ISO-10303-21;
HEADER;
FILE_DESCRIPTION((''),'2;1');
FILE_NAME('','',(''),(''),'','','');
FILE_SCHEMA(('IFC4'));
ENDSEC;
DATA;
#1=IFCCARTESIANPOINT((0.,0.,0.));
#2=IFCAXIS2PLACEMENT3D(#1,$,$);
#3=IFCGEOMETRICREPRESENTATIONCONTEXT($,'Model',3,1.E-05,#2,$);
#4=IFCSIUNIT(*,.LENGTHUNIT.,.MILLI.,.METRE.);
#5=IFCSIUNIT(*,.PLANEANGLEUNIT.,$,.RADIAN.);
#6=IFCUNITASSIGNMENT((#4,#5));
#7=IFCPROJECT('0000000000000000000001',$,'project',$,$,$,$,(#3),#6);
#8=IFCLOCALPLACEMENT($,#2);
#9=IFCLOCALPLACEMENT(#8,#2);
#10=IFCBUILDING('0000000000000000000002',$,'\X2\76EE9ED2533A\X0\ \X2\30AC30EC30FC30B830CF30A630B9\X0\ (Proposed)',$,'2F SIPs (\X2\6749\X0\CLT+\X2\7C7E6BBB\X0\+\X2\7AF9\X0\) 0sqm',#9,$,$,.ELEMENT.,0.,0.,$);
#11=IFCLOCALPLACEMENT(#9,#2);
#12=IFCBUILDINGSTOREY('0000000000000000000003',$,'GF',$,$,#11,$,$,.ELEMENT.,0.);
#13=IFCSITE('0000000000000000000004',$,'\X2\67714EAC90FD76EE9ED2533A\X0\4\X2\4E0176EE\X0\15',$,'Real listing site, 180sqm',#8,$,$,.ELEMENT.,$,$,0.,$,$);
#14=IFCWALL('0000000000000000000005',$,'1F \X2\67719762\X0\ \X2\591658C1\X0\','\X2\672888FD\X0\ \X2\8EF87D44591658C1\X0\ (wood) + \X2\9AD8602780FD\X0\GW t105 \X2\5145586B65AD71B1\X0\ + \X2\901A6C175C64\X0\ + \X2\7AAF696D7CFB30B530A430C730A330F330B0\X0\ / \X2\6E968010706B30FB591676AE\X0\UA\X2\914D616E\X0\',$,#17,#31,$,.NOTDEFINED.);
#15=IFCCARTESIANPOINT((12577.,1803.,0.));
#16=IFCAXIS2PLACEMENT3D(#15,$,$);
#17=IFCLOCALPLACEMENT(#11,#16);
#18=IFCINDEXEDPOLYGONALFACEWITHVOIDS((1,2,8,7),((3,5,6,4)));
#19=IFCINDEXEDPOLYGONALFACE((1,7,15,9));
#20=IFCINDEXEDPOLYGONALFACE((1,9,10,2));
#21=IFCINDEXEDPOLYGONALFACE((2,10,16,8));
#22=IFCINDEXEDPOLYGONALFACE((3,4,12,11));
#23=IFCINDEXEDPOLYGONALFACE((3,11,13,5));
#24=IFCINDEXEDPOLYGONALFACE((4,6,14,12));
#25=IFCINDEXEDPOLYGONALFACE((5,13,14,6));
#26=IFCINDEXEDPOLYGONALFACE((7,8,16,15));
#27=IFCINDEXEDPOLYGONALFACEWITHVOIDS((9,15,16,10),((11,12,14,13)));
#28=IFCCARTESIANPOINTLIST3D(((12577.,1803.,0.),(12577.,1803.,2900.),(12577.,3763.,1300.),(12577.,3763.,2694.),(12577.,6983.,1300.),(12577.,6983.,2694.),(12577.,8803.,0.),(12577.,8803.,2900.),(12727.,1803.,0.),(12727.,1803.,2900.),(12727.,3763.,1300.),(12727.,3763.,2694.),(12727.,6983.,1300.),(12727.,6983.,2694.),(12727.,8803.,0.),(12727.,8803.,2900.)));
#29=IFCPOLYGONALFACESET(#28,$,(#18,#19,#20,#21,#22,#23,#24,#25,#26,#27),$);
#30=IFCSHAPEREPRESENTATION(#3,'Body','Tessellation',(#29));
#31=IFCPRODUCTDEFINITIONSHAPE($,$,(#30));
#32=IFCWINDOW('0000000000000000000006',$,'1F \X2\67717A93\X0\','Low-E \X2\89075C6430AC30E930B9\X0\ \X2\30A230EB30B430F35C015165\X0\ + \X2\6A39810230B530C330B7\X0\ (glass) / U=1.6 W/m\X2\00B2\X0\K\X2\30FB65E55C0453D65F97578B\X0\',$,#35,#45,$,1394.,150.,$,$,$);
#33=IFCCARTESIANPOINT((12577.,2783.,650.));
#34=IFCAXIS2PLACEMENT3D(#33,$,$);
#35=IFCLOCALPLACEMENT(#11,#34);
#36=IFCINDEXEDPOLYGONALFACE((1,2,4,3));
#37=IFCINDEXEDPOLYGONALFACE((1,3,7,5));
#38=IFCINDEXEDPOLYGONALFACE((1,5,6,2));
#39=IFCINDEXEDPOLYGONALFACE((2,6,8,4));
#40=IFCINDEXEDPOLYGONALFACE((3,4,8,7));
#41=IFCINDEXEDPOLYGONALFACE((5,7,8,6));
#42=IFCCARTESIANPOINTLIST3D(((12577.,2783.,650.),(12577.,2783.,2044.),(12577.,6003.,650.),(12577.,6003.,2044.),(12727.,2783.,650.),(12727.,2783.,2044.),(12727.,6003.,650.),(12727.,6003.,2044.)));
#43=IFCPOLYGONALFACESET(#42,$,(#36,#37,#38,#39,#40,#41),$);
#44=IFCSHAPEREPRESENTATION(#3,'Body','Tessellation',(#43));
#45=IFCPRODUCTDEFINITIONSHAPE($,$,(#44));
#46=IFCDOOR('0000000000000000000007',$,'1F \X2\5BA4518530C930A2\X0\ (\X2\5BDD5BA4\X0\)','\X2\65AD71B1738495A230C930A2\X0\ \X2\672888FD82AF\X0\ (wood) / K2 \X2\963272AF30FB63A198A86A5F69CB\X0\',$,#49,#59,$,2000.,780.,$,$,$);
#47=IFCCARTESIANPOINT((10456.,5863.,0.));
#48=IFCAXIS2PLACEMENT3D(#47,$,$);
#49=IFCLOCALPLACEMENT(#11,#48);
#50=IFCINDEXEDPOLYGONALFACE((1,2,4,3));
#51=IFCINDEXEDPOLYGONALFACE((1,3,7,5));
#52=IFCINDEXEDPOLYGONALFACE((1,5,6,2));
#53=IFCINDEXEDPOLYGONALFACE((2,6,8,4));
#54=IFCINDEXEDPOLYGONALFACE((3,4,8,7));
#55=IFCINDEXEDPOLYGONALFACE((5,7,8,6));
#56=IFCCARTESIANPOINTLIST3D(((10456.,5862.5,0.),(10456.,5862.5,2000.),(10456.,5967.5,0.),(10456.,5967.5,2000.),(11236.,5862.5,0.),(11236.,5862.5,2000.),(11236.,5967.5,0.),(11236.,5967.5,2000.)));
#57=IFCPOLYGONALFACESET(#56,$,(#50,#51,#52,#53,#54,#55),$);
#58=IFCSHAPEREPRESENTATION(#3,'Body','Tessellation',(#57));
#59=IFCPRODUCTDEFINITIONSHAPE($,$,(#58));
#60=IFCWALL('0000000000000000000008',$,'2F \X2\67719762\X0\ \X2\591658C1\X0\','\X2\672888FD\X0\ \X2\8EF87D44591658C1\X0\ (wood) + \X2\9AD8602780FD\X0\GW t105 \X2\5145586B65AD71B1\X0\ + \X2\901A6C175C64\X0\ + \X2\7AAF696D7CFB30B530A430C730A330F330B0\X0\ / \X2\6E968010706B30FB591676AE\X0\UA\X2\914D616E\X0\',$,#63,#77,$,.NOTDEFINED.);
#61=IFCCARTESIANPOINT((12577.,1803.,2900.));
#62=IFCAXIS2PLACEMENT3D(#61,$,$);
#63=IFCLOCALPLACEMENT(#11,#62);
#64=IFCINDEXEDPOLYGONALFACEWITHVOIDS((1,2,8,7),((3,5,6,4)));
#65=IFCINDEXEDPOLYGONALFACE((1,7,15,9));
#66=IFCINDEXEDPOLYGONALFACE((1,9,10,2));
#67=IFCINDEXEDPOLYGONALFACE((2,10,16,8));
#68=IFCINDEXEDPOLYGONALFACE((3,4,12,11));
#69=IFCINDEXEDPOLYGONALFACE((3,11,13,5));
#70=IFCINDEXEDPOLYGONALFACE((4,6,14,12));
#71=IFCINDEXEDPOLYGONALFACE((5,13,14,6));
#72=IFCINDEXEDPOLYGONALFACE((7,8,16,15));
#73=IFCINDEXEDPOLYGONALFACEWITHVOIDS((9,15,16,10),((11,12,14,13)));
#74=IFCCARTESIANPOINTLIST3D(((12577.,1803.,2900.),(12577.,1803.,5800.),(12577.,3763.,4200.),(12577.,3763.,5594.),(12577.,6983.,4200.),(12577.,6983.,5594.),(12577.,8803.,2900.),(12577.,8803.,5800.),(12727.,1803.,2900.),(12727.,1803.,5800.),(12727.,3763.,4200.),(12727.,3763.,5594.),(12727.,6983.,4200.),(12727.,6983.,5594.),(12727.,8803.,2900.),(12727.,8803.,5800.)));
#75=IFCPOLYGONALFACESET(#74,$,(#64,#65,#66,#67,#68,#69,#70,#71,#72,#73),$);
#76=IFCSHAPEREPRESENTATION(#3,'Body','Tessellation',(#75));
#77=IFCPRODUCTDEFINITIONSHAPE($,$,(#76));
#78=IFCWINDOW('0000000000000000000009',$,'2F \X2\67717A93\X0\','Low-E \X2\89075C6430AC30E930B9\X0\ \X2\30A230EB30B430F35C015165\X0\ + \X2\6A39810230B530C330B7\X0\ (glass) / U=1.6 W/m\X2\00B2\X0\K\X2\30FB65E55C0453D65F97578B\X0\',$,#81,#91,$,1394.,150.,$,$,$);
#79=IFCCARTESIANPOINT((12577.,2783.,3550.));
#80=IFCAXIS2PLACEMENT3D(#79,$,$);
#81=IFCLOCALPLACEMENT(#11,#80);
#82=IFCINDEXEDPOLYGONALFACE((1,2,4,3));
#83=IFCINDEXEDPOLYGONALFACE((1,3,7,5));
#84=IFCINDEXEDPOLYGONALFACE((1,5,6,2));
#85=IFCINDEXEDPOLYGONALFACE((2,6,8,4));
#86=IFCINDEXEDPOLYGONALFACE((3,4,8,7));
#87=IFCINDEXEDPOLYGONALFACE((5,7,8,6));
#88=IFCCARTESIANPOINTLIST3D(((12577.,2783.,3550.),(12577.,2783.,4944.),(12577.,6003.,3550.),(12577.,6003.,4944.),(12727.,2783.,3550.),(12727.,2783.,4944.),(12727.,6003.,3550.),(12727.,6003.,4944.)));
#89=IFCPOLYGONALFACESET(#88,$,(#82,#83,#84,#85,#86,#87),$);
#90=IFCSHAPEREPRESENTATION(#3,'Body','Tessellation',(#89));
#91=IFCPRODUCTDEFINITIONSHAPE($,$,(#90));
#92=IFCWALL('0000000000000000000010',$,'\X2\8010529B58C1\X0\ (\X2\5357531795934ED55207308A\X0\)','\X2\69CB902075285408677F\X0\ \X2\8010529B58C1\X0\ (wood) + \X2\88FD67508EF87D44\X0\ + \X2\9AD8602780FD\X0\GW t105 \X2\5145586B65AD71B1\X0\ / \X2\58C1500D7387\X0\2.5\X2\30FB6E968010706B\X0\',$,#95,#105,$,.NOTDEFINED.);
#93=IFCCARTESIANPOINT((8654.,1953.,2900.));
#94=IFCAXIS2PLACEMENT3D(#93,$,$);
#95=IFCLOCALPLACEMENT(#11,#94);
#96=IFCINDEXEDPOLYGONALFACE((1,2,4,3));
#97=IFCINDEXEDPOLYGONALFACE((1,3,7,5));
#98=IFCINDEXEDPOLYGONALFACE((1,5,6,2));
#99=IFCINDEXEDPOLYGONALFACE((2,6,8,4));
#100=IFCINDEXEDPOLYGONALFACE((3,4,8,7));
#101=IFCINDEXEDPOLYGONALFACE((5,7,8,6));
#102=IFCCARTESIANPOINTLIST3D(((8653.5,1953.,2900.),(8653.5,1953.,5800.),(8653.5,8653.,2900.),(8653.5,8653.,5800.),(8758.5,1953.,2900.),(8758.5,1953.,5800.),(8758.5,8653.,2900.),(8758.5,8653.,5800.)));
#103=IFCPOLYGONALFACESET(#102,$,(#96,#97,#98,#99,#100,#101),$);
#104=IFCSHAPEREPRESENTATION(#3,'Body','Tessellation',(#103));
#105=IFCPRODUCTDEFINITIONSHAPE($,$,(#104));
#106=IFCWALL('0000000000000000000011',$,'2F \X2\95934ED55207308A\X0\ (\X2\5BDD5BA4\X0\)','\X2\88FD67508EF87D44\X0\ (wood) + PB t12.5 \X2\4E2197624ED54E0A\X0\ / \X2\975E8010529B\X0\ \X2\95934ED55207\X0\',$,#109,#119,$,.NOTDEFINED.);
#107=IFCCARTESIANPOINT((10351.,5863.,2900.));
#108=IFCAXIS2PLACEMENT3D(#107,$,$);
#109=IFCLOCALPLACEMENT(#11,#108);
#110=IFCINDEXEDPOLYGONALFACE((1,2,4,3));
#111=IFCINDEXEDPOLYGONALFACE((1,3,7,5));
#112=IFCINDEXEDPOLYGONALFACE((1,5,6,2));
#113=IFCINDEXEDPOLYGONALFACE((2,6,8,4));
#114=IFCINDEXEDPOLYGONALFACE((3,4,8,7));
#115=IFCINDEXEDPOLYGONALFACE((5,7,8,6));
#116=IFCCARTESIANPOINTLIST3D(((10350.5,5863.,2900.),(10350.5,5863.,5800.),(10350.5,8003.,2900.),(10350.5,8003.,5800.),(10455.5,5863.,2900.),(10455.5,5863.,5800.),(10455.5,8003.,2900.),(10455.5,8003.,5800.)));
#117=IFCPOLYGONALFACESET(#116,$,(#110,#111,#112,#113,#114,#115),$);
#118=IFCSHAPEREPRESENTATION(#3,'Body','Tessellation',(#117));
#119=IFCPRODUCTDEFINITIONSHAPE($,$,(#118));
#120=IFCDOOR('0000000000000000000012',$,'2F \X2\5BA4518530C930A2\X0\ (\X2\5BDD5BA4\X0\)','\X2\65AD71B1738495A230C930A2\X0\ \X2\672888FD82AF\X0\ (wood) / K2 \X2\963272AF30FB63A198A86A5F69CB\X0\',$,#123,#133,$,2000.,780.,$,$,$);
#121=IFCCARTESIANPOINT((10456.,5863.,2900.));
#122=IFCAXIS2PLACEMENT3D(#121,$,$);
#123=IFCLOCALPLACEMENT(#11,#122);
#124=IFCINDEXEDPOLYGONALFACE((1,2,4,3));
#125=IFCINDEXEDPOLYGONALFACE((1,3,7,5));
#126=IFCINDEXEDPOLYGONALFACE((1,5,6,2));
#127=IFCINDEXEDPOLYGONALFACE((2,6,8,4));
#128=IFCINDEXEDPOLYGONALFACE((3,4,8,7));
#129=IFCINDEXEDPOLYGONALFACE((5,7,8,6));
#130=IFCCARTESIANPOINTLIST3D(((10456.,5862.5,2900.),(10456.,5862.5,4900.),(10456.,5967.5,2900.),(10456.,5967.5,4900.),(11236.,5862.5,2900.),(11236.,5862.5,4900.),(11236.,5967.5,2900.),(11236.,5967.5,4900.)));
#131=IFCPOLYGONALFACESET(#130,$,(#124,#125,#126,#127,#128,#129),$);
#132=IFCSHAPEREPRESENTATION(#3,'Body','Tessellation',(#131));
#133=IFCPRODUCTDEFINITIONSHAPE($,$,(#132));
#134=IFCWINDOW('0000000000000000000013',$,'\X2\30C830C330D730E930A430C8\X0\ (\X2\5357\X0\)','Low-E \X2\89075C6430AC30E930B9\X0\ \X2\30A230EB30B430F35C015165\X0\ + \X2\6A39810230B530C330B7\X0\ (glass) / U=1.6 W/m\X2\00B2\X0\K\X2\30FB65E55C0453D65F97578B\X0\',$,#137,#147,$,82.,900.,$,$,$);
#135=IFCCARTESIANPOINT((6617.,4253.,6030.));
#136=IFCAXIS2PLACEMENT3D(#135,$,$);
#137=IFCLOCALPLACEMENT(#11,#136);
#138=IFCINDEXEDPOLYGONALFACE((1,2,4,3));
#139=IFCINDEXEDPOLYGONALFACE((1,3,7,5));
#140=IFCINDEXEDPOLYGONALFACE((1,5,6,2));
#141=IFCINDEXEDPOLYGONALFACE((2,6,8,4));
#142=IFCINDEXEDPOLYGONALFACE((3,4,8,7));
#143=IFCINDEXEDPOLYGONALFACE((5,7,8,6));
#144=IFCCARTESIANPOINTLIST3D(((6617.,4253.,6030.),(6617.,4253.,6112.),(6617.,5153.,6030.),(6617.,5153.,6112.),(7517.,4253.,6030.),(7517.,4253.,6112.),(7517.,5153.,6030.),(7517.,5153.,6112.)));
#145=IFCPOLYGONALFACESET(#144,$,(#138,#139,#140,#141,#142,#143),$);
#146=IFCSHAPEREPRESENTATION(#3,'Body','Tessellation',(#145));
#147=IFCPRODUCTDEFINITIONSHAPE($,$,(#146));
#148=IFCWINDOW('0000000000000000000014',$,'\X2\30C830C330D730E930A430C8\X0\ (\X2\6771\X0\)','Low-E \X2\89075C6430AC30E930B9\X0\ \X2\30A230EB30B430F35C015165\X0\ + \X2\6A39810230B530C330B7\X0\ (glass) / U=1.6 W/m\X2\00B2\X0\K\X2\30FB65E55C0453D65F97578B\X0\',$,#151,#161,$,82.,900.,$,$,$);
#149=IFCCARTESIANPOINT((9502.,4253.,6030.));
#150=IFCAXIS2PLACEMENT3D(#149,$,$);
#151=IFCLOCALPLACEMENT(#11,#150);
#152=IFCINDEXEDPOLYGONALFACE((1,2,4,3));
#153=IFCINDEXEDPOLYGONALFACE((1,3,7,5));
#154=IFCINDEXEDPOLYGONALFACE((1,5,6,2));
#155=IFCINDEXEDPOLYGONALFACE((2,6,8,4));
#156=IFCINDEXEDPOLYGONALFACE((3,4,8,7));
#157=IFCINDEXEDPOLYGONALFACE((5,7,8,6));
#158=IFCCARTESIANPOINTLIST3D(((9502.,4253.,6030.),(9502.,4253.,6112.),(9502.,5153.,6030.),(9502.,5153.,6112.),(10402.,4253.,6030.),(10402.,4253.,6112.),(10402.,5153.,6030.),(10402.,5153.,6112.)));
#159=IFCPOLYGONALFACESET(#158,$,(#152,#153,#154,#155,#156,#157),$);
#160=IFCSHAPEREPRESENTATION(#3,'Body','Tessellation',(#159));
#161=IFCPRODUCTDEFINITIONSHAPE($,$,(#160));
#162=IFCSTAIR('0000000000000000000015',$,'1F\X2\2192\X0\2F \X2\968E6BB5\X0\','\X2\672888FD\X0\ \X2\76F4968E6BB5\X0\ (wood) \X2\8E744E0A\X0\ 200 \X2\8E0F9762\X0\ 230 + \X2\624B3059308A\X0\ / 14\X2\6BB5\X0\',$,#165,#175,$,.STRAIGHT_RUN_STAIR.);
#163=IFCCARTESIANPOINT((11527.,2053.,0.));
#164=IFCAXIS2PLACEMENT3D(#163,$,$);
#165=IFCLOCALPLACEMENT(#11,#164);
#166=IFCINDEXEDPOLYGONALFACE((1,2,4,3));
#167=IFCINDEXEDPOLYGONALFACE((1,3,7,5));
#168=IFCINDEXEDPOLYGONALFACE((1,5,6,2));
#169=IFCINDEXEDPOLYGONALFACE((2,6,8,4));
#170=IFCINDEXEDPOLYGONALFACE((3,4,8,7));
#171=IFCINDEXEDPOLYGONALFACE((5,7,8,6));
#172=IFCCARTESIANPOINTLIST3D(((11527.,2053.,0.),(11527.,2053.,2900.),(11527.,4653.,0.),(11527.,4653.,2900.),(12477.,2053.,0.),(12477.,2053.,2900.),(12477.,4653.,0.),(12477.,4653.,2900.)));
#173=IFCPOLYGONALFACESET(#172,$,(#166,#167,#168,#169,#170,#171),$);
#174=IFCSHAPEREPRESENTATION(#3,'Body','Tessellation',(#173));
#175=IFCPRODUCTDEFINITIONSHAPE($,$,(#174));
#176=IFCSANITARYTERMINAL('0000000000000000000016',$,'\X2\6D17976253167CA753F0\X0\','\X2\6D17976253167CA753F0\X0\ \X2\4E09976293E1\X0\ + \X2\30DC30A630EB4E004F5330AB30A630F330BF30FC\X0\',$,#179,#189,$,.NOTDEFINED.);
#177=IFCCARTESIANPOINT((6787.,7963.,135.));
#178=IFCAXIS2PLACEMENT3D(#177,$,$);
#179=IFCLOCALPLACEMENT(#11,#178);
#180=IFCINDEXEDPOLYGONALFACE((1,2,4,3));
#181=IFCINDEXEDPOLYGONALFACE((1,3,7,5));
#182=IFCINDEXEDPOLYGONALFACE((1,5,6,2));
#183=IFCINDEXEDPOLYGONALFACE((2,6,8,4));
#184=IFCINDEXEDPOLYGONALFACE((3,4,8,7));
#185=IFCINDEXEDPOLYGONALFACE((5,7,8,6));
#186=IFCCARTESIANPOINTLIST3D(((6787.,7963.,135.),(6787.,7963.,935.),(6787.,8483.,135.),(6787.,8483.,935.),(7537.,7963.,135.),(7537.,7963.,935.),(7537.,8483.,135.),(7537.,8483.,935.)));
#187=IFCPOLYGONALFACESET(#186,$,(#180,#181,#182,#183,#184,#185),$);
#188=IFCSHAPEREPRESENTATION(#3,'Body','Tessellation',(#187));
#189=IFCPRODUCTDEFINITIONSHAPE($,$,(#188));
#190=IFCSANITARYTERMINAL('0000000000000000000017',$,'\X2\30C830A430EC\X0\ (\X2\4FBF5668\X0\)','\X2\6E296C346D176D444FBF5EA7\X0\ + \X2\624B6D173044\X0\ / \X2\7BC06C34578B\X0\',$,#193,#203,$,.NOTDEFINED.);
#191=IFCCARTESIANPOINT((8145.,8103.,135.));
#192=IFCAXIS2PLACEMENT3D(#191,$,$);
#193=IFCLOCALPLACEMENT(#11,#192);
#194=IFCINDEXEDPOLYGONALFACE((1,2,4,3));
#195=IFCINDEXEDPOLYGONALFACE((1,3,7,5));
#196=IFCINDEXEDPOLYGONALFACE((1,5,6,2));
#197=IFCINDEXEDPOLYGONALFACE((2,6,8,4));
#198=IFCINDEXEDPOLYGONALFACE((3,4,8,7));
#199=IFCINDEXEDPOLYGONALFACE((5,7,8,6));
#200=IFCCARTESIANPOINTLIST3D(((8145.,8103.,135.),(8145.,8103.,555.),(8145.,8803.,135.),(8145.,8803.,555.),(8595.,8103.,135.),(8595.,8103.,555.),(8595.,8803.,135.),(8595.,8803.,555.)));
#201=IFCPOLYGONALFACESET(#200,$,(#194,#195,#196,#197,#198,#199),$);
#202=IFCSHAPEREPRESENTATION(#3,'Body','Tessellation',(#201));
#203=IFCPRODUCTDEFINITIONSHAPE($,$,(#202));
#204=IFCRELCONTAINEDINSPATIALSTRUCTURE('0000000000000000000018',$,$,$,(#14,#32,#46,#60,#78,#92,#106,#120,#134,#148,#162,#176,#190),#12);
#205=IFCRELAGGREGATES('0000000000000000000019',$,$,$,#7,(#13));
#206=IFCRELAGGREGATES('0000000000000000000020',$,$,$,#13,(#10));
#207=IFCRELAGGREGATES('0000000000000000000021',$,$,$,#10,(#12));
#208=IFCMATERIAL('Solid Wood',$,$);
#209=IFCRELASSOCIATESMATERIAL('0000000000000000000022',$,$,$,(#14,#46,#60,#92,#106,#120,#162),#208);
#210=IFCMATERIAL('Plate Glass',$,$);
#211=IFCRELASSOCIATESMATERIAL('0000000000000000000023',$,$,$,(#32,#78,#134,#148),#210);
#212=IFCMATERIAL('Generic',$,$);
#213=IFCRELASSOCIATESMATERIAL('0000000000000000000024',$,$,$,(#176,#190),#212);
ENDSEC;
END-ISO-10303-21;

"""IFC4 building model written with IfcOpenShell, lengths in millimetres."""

from ifc_helpers import new_model, si_unit, frame, frame_2d, origin, place, context, project, spatial, rectangle, extrude, material, element, fill, save


model = new_model("IFC4")

# Units and contexts
model_context = context("Model", 3, precision=1e-05, world=origin())
ifc_project = project(units=[si_unit("LENGTHUNIT", "METRE", prefix="MILLI"), si_unit("PLANEANGLEUNIT", "RADIAN")], contexts=[model_context])

# Site, building, storey
site_placement = place(None, origin())
site = spatial("IfcSite", under=ifc_project, at=site_placement, Name="東京都目黒区4丁目15", ObjectType="Real listing site, 180sqm", CompositionType="ELEMENT", RefElevation=0.0)
building_placement = place(site_placement, origin())
building = spatial("IfcBuilding", under=site, at=building_placement, Name="目黒区 ガレージハウス (Proposed)", ObjectType="2F SIPs (杉CLT+籾殻+竹) 0sqm", CompositionType="ELEMENT", ElevationOfRefHeight=0.0, ElevationOfTerrain=0.0)
storey_placement = place(building_placement, origin())
storey = spatial("IfcBuildingStorey", under=building, at=storey_placement, Name="GF", CompositionType="ELEMENT", Elevation=0.0)

# Wall, opening, window
ifc_material_1 = material(Name="Solid Wood")
wall_1_placement = place(storey_placement, frame((12577.0, 1803.0, 0.0)))
wall_1 = element("IfcWall", 1, at=wall_1_placement, inside=storey, material=ifc_material_1, Name="1F 東面 外壁", Description="木製 軸組外壁 (wood) + 高性能GW t105 充填断熱 + 通気層 + 窯業系サイディング / 準耐火・外皮UA配慮", PredefinedType="NOTDEFINED", context=model_context, shape_type="SweptSolid", body=[
    extrude(rectangle(XDim=150.0, YDim=7000.0, at=frame_2d((75.0, 3500.0))), frame((12577.0, 1803.0, 0.0)), (0.0, 0.0, 1.0), 2900.0),
])
opening_1_placement = place(storey_placement, frame((12577.0, 2783.0, 650.0)))
opening_1 = element("IfcOpeningElement", 2, at=opening_1_placement, cuts=wall_1, PredefinedType="NOTDEFINED", context=model_context, shape_type="SweptSolid", body=[
    extrude(rectangle(XDim=150.0, YDim=3220.0, at=frame_2d((75.0, 1610.0))), frame((12577.0, 2783.0, 650.0)), (0.0, 0.0, 1.0), 1394.0),
])
ifc_material_2 = material(Name="Plate Glass")
window_1_placement = place(storey_placement, frame((12577.0, 2783.0, 650.0)))
window_1 = element("IfcWindow", 3, at=window_1_placement, inside=storey, material=ifc_material_2, Name="1F 東窓", Description="Low-E 複層ガラス アルゴン封入 + 樹脂サッシ (glass) / U=1.6 W/m²K・日射取得型", OverallHeight=1394.0, OverallWidth=150.0, context=model_context, shape_type="SweptSolid", body=[
    extrude(rectangle(XDim=150.0, YDim=3220.0, at=frame_2d((75.0, 1610.0))), frame((12577.0, 2783.0, 650.0)), (0.0, 0.0, 1.0), 1394.0),
])
fill(opening_1, window_1)

# Door
door_1_placement = place(storey_placement, frame((10456.0, 5863.0, 0.0)))
element("IfcDoor", 4, at=door_1_placement, inside=storey, material=ifc_material_1, Name="1F 室内ドア (寝室)", Description="断熱玄関ドア 木製芯 (wood) / K2 防犯・採風機構", OverallHeight=2000.0, OverallWidth=780.0, context=model_context, shape_type="SweptSolid", body=[
    extrude(rectangle(XDim=780.0, YDim=105.0, at=frame_2d((390.0, 52.0))), frame((10456.0, 5863.0, 0.0)), (0.0, 0.0, 1.0), 2000.0),
])

# Wall, opening, window
wall_2_placement = place(storey_placement, frame((12577.0, 1803.0, 2900.0)))
wall_2 = element("IfcWall", 5, at=wall_2_placement, inside=storey, material=ifc_material_1, Name="2F 東面 外壁", Description="木製 軸組外壁 (wood) + 高性能GW t105 充填断熱 + 通気層 + 窯業系サイディング / 準耐火・外皮UA配慮", PredefinedType="NOTDEFINED", context=model_context, shape_type="SweptSolid", body=[
    extrude(rectangle(XDim=150.0, YDim=7000.0, at=frame_2d((75.0, 3500.0))), frame((12577.0, 1803.0, 2900.0)), (0.0, 0.0, 1.0), 2900.0),
])
opening_2_placement = place(storey_placement, frame((12577.0, 2783.0, 3550.0)))
opening_2 = element("IfcOpeningElement", 6, at=opening_2_placement, cuts=wall_2, PredefinedType="NOTDEFINED", context=model_context, shape_type="SweptSolid", body=[
    extrude(rectangle(XDim=150.0, YDim=3220.0, at=frame_2d((75.0, 1610.0))), frame((12577.0, 2783.0, 3550.0)), (0.0, 0.0, 1.0), 1394.0),
])
window_2_placement = place(storey_placement, frame((12577.0, 2783.0, 3550.0)))
window_2 = element("IfcWindow", 7, at=window_2_placement, inside=storey, material=ifc_material_2, Name="2F 東窓", Description="Low-E 複層ガラス アルゴン封入 + 樹脂サッシ (glass) / U=1.6 W/m²K・日射取得型", OverallHeight=1394.0, OverallWidth=150.0, context=model_context, shape_type="SweptSolid", body=[
    extrude(rectangle(XDim=150.0, YDim=3220.0, at=frame_2d((75.0, 1610.0))), frame((12577.0, 2783.0, 3550.0)), (0.0, 0.0, 1.0), 1394.0),
])
fill(opening_2, window_2)

# Walls
wall_3_placement = place(storey_placement, frame((8654.0, 1953.0, 2900.0)))
element("IfcWall", 8, at=wall_3_placement, inside=storey, material=ifc_material_1, Name="耐力壁 (南北間仕切り)", Description="構造用合板 耐力壁 (wood) + 製材軸組 + 高性能GW t105 充填断熱 / 壁倍率2.5・準耐火", PredefinedType="NOTDEFINED", context=model_context, shape_type="SweptSolid", body=[
    extrude(rectangle(XDim=105.0, YDim=6700.0, at=frame_2d((52.0, 3350.0))), frame((8654.0, 1953.0, 2900.0)), (0.0, 0.0, 1.0), 2900.0),
])
wall_4_placement = place(storey_placement, frame((10351.0, 5863.0, 2900.0)))
element("IfcWall", 9, at=wall_4_placement, inside=storey, material=ifc_material_1, Name="2F 間仕切り (寝室)", Description="製材軸組 (wood) + PB t12.5 両面仕上 / 非耐力 間仕切", PredefinedType="NOTDEFINED", context=model_context, shape_type="SweptSolid", body=[
    extrude(rectangle(XDim=105.0, YDim=2140.0, at=frame_2d((52.0, 1070.0))), frame((10351.0, 5863.0, 2900.0)), (0.0, 0.0, 1.0), 2900.0),
])

# Door
door_2_placement = place(storey_placement, frame((10456.0, 5863.0, 2900.0)))
element("IfcDoor", 10, at=door_2_placement, inside=storey, material=ifc_material_1, Name="2F 室内ドア (寝室)", Description="断熱玄関ドア 木製芯 (wood) / K2 防犯・採風機構", OverallHeight=2000.0, OverallWidth=780.0, context=model_context, shape_type="SweptSolid", body=[
    extrude(rectangle(XDim=780.0, YDim=105.0, at=frame_2d((390.0, 52.0))), frame((10456.0, 5863.0, 2900.0)), (0.0, 0.0, 1.0), 2000.0),
])

# Windows
window_3_placement = place(storey_placement, frame((6617.0, 4253.0, 6030.0)))
element("IfcWindow", 11, at=window_3_placement, inside=storey, material=ifc_material_2, Name="トップライト (南)", Description="Low-E 複層ガラス アルゴン封入 + 樹脂サッシ (glass) / U=1.6 W/m²K・日射取得型", OverallHeight=82.0, OverallWidth=900.0, context=model_context, shape_type="SweptSolid", body=[
    extrude(rectangle(XDim=900.0, YDim=900.0, at=frame_2d((450.0, 450.0))), frame((6617.0, 4253.0, 6030.0)), (0.0, 0.0, 1.0), 82.0),
])
window_4_placement = place(storey_placement, frame((9502.0, 4253.0, 6030.0)))
element("IfcWindow", 12, at=window_4_placement, inside=storey, material=ifc_material_2, Name="トップライト (東)", Description="Low-E 複層ガラス アルゴン封入 + 樹脂サッシ (glass) / U=1.6 W/m²K・日射取得型", OverallHeight=82.0, OverallWidth=900.0, context=model_context, shape_type="SweptSolid", body=[
    extrude(rectangle(XDim=900.0, YDim=900.0, at=frame_2d((450.0, 450.0))), frame((9502.0, 4253.0, 6030.0)), (0.0, 0.0, 1.0), 82.0),
])

# Stair
stair_placement = place(storey_placement, frame((11527.0, 2053.0, 0.0)))
element("IfcStair", 13, at=stair_placement, inside=storey, material=ifc_material_1, Name="1F→2F 階段", Description="木製 直階段 (wood) 蹴上 200 踏面 230 + 手すり / 14段", PredefinedType="STRAIGHT_RUN_STAIR", context=model_context, shape_type="SweptSolid", body=[
    extrude(rectangle(XDim=950.0, YDim=2600.0, at=frame_2d((475.0, 1300.0))), frame((11527.0, 2053.0, 0.0)), (0.0, 0.0, 1.0), 2900.0),
])

# Sanitary terminals
ifc_material_3 = material(Name="Generic")
sanitary_terminal_1_placement = place(storey_placement, frame((6787.0, 7963.0, 135.0)))
element("IfcSanitaryTerminal", 14, at=sanitary_terminal_1_placement, inside=storey, material=ifc_material_3, Name="洗面化粧台", Description="洗面化粧台 三面鏡 + ボウル一体カウンター", PredefinedType="NOTDEFINED", context=model_context, shape_type="SweptSolid", body=[
    extrude(rectangle(XDim=750.0, YDim=520.0, at=frame_2d((375.0, 260.0))), frame((6787.0, 7963.0, 135.0)), (0.0, 0.0, 1.0), 800.0),
])
sanitary_terminal_2_placement = place(storey_placement, frame((8145.0, 8103.0, 135.0)))
element("IfcSanitaryTerminal", 15, at=sanitary_terminal_2_placement, inside=storey, material=ifc_material_3, Name="トイレ (便器)", Description="温水洗浄便座 + 手洗い / 節水型", PredefinedType="NOTDEFINED", context=model_context, shape_type="SweptSolid", body=[
    extrude(rectangle(XDim=450.0, YDim=700.0, at=frame_2d((225.0, 350.0))), frame((8145.0, 8103.0, 135.0)), (0.0, 0.0, 1.0), 420.0),
])

save(model, "model.ifc")
